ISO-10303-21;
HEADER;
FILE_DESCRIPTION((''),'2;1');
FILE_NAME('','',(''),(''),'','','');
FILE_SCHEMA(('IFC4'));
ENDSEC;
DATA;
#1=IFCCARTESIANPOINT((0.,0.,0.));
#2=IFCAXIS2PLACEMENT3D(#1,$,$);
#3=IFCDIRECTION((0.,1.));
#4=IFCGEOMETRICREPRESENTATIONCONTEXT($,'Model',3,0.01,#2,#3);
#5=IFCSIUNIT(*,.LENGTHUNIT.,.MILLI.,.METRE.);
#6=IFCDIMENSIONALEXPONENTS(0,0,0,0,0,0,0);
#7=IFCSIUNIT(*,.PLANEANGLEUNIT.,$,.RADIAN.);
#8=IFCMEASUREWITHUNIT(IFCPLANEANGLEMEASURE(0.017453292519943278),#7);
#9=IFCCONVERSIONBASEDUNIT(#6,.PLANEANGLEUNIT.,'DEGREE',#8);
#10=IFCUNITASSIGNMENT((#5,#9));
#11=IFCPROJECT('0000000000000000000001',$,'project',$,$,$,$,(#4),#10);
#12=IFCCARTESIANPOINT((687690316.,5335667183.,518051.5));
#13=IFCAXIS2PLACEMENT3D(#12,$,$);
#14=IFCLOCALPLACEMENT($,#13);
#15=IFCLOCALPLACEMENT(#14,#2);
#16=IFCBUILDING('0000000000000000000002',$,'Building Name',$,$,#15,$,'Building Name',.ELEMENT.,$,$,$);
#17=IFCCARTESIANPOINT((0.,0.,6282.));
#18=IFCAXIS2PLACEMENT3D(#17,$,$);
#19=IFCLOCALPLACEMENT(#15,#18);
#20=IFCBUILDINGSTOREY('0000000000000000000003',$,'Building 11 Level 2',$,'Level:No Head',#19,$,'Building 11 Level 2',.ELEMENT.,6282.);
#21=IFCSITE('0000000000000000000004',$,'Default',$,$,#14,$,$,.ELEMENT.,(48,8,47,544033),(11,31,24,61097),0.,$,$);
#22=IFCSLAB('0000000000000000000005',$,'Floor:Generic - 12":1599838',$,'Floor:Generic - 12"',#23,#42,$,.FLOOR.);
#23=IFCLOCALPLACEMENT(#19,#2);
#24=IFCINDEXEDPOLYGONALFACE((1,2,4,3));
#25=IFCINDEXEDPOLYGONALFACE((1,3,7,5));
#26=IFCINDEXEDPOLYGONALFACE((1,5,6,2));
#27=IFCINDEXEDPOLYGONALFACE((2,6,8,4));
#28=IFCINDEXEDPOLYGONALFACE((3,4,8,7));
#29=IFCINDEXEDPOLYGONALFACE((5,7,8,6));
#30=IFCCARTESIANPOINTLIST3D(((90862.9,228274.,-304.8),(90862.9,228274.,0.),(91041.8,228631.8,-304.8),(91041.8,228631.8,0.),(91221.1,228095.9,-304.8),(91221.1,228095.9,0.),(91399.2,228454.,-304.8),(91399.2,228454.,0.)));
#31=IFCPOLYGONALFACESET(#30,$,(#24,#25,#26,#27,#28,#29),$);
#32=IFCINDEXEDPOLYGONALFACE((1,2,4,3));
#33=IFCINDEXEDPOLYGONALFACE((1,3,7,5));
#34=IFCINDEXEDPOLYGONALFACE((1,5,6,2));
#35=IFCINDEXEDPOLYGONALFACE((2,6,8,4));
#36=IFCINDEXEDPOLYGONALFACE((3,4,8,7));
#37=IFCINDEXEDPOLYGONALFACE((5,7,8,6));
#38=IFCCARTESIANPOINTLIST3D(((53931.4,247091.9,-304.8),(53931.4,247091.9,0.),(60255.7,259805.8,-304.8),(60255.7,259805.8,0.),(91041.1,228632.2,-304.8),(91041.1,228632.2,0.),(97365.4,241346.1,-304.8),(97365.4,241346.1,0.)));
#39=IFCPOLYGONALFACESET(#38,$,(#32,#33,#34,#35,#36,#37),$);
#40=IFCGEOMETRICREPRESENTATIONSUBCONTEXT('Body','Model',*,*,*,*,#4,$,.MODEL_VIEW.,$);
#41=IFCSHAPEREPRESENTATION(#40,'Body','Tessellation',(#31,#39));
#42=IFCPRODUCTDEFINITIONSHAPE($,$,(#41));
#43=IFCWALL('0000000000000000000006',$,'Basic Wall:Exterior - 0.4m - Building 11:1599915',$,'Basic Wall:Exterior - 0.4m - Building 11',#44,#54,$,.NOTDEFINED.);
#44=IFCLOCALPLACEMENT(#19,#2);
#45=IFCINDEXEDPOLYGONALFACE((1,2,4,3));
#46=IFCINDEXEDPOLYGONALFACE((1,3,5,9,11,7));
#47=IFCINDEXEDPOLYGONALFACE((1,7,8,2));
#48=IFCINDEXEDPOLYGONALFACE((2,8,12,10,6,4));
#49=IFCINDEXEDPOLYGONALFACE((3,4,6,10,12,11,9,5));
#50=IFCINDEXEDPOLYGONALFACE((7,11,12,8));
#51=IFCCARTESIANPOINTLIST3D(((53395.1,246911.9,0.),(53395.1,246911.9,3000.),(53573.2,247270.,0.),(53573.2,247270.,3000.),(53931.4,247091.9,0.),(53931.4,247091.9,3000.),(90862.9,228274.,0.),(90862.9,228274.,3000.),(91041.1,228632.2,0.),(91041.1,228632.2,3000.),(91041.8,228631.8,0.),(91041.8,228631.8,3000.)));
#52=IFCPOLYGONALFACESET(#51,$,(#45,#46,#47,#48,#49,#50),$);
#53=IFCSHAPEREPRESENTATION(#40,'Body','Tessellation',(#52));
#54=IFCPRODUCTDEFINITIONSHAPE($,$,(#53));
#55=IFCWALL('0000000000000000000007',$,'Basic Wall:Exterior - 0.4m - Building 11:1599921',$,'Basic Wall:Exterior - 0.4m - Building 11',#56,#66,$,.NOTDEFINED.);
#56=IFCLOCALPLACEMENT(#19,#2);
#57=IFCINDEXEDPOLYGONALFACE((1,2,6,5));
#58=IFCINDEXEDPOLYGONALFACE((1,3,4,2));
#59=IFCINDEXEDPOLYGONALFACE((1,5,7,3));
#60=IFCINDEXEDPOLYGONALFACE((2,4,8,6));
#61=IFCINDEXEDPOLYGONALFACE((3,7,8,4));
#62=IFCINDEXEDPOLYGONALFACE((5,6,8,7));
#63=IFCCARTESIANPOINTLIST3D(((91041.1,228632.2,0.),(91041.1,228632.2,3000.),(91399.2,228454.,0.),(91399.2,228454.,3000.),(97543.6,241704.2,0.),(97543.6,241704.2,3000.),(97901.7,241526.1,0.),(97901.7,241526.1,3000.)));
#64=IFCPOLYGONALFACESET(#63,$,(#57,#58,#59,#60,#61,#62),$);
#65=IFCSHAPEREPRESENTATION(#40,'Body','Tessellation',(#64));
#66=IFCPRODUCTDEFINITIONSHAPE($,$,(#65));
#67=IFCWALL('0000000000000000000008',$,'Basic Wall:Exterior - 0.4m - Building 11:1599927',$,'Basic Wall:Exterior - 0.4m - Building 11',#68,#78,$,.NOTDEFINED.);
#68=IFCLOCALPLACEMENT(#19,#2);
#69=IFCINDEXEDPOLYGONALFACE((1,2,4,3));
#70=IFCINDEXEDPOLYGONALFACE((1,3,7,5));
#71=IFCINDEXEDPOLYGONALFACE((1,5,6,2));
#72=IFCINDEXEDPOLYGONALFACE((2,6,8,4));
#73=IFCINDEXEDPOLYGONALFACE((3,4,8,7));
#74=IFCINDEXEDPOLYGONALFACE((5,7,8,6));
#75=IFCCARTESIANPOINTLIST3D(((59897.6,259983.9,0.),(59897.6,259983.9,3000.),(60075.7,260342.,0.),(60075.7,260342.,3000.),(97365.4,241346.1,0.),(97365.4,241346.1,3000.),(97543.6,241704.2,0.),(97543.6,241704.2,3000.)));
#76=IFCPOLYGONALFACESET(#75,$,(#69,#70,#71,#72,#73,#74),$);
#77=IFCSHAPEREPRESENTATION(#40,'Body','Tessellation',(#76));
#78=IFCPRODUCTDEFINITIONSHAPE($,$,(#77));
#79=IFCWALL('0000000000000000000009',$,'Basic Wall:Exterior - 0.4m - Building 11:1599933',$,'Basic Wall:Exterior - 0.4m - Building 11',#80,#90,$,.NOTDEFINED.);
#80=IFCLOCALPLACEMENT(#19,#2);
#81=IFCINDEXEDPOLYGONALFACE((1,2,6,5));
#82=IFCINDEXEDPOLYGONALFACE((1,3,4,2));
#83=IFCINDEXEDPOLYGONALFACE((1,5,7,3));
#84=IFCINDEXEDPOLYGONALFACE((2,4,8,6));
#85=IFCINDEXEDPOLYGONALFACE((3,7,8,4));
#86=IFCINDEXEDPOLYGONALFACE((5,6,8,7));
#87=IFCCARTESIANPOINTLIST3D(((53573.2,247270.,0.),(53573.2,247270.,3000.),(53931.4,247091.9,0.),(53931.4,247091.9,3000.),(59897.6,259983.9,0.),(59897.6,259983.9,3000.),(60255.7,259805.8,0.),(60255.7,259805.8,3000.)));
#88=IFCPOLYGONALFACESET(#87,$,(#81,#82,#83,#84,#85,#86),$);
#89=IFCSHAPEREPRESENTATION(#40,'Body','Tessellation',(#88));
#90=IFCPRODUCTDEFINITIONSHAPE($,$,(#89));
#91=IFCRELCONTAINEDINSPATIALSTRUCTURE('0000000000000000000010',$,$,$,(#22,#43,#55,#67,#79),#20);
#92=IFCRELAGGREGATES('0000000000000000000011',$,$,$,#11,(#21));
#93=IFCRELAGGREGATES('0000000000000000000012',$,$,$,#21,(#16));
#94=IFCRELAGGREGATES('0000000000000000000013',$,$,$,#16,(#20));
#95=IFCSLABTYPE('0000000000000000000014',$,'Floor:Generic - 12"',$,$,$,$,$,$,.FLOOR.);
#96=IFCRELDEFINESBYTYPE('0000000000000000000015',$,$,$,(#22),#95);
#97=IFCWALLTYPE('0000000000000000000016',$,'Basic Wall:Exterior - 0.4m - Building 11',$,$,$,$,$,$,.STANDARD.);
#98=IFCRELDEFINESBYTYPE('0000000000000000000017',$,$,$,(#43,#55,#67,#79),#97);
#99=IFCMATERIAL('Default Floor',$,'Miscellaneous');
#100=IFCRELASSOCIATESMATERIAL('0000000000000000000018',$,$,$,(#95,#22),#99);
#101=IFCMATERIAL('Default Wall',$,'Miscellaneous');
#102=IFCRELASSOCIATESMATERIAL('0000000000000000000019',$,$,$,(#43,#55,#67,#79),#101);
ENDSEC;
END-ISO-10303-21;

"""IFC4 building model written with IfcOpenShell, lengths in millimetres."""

from ifc_helpers import new_model, entity, si_unit, converted_unit, direction, frame, origin, place, context, subcontext, project, spatial, indexed_curve, outline, extrude, material, type_object, element, save


model = new_model("IFC4")

# Units and contexts
model_context = context("Model", 3, precision=0.01, world=origin(), true_north=direction((0.0, 1.0)))
body_context = subcontext(model_context, "Body", "Model", "MODEL_VIEW")
ifc_project = project(units=[si_unit("LENGTHUNIT", "METRE", prefix="MILLI"), converted_unit("PLANEANGLEUNIT", "DEGREE", entity("IfcPlaneAngleMeasure", 0.017453292519943278), si_unit("PLANEANGLEUNIT", "RADIAN"), dimensions=[0, 0, 0, 0, 0, 0, 0])], contexts=[model_context])

# Site, building, storey
site_placement = place(None, frame((687690316.0, 5335667183.0, 518051.5)))
site = spatial("IfcSite", under=ifc_project, at=site_placement, Name="Default", CompositionType="ELEMENT", RefLatitude=(48, 8, 47, 544033), RefLongitude=(11, 31, 24, 61097), RefElevation=0.0)
building_placement = place(site_placement, origin())
building = spatial("IfcBuilding", under=site, at=building_placement, Name="Building Name", LongName="Building Name", CompositionType="ELEMENT")
storey_placement = place(building_placement, frame((0.0, 0.0, 6282.0)))
storey = spatial("IfcBuildingStorey", under=building, at=storey_placement, Name="Building 11 Level 2", ObjectType="Level:No Head", LongName="Building 11 Level 2", CompositionType="ELEMENT", Elevation=6282.0)

# Slab
ifc_material_1 = material(Name="Default Floor", Category="Miscellaneous")
slab_type = type_object("IfcSlabType", Name="Floor:Generic - 12\"", PredefinedType="FLOOR", material=ifc_material_1)
slab_placement = place(storey_placement, origin())
element("IfcSlab", 1, at=slab_placement, inside=storey, type_object=slab_type, material=ifc_material_1, Name="Floor:Generic - 12\":1599838", ObjectType="Floor:Generic - 12\"", PredefinedType="FLOOR", context=body_context, shape_type="SweptSolid", body=[
    extrude(outline(indexed_curve([(-199.6, -199.8), (200.4, -199.8), (199.6, 200.2), (-200.4, 199.4), (-199.6, -199.8)], self_intersect=False)), frame((91131.2, 228363.9, -304.8), z_axis=(0.0, 0.0, 1.0), x_axis=(-0.447226, -0.894421, 0.0)), (0.0, 0.0, 1.0), 304.8),
    extrude(outline(indexed_curve([(-20723.7, -7100.0), (20723.7, -7100.0), (20723.7, 7100.0), (-20723.7, 7100.0), (-20723.7, -7100.0)], self_intersect=False)), frame((75648.4, 244219.0, -304.8), z_axis=(0.0, 0.0, 1.0), x_axis=(-0.895344, 0.445376, 0.0)), (0.0, 0.0, 1.0), 304.8),
])

# Walls
ifc_material_2 = material(Name="Default Wall", Category="Miscellaneous")
wall_type = type_object("IfcWallType", Name="Basic Wall:Exterior - 0.4m - Building 11", PredefinedType="STANDARD")
wall_1_placement = place(storey_placement, frame((53484.2, 247091.0, 0.0), z_axis=(0.0, 0.0, 1.0), x_axis=(0.895344, -0.445376, 0.0)))
element("IfcWall", 2, at=wall_1_placement, inside=storey, type_object=wall_type, material=ifc_material_2, Name="Basic Wall:Exterior - 0.4m - Building 11:1599915", ObjectType="Basic Wall:Exterior - 0.4m - Building 11", PredefinedType="NOTDEFINED", context=body_context, shape_type="SweptSolid", body=[
    extrude(outline(indexed_curve([(41847.4, -200.0), (41848.3, 200.0), (41847.4, 200.0), (400.0, 200.0), (0.0, 200.0), (0.0, -200.0), (41847.4, -200.0)], self_intersect=False)), origin(), (0.0, 0.0, 1.0), 3000.0),
])
wall_2_placement = place(storey_placement, frame((91220.1, 228543.1, 0.0), z_axis=(0.0, 0.0, 1.0), x_axis=(0.445376, 0.895344, 0.0)))
element("IfcWall", 3, at=wall_2_placement, inside=storey, type_object=wall_type, material=ifc_material_2, Name="Basic Wall:Exterior - 0.4m - Building 11:1599921", ObjectType="Basic Wall:Exterior - 0.4m - Building 11", PredefinedType="NOTDEFINED", context=body_context, shape_type="SweptSolid", body=[
    extrude(outline(indexed_curve([(14600.0, 200.0), (0.0, 200.0), (0.0, -200.0), (14600.0, -200.0), (14600.0, 200.0)], self_intersect=False)), origin(), (0.0, 0.0, 1.0), 3000.0),
])
wall_3_placement = place(storey_placement, frame((97454.5, 241525.1, 0.0), z_axis=(0.0, 0.0, 1.0), x_axis=(-0.895344, 0.445376, 0.0)))
element("IfcWall", 4, at=wall_3_placement, inside=storey, type_object=wall_type, material=ifc_material_2, Name="Basic Wall:Exterior - 0.4m - Building 11:1599927", ObjectType="Basic Wall:Exterior - 0.4m - Building 11", PredefinedType="NOTDEFINED", context=body_context, shape_type="SweptSolid", body=[
    extrude(outline(indexed_curve([(41847.4, 200.0), (0.0, 200.0), (0.0, -200.0), (41847.4, -200.0), (41847.4, 200.0)], self_intersect=False)), origin(), (0.0, 0.0, 1.0), 3000.0),
])
wall_4_placement = place(storey_placement, frame((60076.6, 259894.8, 0.0), z_axis=(0.0, 0.0, 1.0), x_axis=(-0.445376, -0.895344, 0.0)))
element("IfcWall", 5, at=wall_4_placement, inside=storey, type_object=wall_type, material=ifc_material_2, Name="Basic Wall:Exterior - 0.4m - Building 11:1599933", ObjectType="Basic Wall:Exterior - 0.4m - Building 11", PredefinedType="NOTDEFINED", context=body_context, shape_type="SweptSolid", body=[
    extrude(outline(indexed_curve([(14200.0, 200.0), (0.0, 200.0), (0.0, -200.0), (14200.0, -200.0), (14200.0, 200.0)], self_intersect=False)), origin(), (0.0, 0.0, 1.0), 3000.0),
])

save(model, "model.ifc")
